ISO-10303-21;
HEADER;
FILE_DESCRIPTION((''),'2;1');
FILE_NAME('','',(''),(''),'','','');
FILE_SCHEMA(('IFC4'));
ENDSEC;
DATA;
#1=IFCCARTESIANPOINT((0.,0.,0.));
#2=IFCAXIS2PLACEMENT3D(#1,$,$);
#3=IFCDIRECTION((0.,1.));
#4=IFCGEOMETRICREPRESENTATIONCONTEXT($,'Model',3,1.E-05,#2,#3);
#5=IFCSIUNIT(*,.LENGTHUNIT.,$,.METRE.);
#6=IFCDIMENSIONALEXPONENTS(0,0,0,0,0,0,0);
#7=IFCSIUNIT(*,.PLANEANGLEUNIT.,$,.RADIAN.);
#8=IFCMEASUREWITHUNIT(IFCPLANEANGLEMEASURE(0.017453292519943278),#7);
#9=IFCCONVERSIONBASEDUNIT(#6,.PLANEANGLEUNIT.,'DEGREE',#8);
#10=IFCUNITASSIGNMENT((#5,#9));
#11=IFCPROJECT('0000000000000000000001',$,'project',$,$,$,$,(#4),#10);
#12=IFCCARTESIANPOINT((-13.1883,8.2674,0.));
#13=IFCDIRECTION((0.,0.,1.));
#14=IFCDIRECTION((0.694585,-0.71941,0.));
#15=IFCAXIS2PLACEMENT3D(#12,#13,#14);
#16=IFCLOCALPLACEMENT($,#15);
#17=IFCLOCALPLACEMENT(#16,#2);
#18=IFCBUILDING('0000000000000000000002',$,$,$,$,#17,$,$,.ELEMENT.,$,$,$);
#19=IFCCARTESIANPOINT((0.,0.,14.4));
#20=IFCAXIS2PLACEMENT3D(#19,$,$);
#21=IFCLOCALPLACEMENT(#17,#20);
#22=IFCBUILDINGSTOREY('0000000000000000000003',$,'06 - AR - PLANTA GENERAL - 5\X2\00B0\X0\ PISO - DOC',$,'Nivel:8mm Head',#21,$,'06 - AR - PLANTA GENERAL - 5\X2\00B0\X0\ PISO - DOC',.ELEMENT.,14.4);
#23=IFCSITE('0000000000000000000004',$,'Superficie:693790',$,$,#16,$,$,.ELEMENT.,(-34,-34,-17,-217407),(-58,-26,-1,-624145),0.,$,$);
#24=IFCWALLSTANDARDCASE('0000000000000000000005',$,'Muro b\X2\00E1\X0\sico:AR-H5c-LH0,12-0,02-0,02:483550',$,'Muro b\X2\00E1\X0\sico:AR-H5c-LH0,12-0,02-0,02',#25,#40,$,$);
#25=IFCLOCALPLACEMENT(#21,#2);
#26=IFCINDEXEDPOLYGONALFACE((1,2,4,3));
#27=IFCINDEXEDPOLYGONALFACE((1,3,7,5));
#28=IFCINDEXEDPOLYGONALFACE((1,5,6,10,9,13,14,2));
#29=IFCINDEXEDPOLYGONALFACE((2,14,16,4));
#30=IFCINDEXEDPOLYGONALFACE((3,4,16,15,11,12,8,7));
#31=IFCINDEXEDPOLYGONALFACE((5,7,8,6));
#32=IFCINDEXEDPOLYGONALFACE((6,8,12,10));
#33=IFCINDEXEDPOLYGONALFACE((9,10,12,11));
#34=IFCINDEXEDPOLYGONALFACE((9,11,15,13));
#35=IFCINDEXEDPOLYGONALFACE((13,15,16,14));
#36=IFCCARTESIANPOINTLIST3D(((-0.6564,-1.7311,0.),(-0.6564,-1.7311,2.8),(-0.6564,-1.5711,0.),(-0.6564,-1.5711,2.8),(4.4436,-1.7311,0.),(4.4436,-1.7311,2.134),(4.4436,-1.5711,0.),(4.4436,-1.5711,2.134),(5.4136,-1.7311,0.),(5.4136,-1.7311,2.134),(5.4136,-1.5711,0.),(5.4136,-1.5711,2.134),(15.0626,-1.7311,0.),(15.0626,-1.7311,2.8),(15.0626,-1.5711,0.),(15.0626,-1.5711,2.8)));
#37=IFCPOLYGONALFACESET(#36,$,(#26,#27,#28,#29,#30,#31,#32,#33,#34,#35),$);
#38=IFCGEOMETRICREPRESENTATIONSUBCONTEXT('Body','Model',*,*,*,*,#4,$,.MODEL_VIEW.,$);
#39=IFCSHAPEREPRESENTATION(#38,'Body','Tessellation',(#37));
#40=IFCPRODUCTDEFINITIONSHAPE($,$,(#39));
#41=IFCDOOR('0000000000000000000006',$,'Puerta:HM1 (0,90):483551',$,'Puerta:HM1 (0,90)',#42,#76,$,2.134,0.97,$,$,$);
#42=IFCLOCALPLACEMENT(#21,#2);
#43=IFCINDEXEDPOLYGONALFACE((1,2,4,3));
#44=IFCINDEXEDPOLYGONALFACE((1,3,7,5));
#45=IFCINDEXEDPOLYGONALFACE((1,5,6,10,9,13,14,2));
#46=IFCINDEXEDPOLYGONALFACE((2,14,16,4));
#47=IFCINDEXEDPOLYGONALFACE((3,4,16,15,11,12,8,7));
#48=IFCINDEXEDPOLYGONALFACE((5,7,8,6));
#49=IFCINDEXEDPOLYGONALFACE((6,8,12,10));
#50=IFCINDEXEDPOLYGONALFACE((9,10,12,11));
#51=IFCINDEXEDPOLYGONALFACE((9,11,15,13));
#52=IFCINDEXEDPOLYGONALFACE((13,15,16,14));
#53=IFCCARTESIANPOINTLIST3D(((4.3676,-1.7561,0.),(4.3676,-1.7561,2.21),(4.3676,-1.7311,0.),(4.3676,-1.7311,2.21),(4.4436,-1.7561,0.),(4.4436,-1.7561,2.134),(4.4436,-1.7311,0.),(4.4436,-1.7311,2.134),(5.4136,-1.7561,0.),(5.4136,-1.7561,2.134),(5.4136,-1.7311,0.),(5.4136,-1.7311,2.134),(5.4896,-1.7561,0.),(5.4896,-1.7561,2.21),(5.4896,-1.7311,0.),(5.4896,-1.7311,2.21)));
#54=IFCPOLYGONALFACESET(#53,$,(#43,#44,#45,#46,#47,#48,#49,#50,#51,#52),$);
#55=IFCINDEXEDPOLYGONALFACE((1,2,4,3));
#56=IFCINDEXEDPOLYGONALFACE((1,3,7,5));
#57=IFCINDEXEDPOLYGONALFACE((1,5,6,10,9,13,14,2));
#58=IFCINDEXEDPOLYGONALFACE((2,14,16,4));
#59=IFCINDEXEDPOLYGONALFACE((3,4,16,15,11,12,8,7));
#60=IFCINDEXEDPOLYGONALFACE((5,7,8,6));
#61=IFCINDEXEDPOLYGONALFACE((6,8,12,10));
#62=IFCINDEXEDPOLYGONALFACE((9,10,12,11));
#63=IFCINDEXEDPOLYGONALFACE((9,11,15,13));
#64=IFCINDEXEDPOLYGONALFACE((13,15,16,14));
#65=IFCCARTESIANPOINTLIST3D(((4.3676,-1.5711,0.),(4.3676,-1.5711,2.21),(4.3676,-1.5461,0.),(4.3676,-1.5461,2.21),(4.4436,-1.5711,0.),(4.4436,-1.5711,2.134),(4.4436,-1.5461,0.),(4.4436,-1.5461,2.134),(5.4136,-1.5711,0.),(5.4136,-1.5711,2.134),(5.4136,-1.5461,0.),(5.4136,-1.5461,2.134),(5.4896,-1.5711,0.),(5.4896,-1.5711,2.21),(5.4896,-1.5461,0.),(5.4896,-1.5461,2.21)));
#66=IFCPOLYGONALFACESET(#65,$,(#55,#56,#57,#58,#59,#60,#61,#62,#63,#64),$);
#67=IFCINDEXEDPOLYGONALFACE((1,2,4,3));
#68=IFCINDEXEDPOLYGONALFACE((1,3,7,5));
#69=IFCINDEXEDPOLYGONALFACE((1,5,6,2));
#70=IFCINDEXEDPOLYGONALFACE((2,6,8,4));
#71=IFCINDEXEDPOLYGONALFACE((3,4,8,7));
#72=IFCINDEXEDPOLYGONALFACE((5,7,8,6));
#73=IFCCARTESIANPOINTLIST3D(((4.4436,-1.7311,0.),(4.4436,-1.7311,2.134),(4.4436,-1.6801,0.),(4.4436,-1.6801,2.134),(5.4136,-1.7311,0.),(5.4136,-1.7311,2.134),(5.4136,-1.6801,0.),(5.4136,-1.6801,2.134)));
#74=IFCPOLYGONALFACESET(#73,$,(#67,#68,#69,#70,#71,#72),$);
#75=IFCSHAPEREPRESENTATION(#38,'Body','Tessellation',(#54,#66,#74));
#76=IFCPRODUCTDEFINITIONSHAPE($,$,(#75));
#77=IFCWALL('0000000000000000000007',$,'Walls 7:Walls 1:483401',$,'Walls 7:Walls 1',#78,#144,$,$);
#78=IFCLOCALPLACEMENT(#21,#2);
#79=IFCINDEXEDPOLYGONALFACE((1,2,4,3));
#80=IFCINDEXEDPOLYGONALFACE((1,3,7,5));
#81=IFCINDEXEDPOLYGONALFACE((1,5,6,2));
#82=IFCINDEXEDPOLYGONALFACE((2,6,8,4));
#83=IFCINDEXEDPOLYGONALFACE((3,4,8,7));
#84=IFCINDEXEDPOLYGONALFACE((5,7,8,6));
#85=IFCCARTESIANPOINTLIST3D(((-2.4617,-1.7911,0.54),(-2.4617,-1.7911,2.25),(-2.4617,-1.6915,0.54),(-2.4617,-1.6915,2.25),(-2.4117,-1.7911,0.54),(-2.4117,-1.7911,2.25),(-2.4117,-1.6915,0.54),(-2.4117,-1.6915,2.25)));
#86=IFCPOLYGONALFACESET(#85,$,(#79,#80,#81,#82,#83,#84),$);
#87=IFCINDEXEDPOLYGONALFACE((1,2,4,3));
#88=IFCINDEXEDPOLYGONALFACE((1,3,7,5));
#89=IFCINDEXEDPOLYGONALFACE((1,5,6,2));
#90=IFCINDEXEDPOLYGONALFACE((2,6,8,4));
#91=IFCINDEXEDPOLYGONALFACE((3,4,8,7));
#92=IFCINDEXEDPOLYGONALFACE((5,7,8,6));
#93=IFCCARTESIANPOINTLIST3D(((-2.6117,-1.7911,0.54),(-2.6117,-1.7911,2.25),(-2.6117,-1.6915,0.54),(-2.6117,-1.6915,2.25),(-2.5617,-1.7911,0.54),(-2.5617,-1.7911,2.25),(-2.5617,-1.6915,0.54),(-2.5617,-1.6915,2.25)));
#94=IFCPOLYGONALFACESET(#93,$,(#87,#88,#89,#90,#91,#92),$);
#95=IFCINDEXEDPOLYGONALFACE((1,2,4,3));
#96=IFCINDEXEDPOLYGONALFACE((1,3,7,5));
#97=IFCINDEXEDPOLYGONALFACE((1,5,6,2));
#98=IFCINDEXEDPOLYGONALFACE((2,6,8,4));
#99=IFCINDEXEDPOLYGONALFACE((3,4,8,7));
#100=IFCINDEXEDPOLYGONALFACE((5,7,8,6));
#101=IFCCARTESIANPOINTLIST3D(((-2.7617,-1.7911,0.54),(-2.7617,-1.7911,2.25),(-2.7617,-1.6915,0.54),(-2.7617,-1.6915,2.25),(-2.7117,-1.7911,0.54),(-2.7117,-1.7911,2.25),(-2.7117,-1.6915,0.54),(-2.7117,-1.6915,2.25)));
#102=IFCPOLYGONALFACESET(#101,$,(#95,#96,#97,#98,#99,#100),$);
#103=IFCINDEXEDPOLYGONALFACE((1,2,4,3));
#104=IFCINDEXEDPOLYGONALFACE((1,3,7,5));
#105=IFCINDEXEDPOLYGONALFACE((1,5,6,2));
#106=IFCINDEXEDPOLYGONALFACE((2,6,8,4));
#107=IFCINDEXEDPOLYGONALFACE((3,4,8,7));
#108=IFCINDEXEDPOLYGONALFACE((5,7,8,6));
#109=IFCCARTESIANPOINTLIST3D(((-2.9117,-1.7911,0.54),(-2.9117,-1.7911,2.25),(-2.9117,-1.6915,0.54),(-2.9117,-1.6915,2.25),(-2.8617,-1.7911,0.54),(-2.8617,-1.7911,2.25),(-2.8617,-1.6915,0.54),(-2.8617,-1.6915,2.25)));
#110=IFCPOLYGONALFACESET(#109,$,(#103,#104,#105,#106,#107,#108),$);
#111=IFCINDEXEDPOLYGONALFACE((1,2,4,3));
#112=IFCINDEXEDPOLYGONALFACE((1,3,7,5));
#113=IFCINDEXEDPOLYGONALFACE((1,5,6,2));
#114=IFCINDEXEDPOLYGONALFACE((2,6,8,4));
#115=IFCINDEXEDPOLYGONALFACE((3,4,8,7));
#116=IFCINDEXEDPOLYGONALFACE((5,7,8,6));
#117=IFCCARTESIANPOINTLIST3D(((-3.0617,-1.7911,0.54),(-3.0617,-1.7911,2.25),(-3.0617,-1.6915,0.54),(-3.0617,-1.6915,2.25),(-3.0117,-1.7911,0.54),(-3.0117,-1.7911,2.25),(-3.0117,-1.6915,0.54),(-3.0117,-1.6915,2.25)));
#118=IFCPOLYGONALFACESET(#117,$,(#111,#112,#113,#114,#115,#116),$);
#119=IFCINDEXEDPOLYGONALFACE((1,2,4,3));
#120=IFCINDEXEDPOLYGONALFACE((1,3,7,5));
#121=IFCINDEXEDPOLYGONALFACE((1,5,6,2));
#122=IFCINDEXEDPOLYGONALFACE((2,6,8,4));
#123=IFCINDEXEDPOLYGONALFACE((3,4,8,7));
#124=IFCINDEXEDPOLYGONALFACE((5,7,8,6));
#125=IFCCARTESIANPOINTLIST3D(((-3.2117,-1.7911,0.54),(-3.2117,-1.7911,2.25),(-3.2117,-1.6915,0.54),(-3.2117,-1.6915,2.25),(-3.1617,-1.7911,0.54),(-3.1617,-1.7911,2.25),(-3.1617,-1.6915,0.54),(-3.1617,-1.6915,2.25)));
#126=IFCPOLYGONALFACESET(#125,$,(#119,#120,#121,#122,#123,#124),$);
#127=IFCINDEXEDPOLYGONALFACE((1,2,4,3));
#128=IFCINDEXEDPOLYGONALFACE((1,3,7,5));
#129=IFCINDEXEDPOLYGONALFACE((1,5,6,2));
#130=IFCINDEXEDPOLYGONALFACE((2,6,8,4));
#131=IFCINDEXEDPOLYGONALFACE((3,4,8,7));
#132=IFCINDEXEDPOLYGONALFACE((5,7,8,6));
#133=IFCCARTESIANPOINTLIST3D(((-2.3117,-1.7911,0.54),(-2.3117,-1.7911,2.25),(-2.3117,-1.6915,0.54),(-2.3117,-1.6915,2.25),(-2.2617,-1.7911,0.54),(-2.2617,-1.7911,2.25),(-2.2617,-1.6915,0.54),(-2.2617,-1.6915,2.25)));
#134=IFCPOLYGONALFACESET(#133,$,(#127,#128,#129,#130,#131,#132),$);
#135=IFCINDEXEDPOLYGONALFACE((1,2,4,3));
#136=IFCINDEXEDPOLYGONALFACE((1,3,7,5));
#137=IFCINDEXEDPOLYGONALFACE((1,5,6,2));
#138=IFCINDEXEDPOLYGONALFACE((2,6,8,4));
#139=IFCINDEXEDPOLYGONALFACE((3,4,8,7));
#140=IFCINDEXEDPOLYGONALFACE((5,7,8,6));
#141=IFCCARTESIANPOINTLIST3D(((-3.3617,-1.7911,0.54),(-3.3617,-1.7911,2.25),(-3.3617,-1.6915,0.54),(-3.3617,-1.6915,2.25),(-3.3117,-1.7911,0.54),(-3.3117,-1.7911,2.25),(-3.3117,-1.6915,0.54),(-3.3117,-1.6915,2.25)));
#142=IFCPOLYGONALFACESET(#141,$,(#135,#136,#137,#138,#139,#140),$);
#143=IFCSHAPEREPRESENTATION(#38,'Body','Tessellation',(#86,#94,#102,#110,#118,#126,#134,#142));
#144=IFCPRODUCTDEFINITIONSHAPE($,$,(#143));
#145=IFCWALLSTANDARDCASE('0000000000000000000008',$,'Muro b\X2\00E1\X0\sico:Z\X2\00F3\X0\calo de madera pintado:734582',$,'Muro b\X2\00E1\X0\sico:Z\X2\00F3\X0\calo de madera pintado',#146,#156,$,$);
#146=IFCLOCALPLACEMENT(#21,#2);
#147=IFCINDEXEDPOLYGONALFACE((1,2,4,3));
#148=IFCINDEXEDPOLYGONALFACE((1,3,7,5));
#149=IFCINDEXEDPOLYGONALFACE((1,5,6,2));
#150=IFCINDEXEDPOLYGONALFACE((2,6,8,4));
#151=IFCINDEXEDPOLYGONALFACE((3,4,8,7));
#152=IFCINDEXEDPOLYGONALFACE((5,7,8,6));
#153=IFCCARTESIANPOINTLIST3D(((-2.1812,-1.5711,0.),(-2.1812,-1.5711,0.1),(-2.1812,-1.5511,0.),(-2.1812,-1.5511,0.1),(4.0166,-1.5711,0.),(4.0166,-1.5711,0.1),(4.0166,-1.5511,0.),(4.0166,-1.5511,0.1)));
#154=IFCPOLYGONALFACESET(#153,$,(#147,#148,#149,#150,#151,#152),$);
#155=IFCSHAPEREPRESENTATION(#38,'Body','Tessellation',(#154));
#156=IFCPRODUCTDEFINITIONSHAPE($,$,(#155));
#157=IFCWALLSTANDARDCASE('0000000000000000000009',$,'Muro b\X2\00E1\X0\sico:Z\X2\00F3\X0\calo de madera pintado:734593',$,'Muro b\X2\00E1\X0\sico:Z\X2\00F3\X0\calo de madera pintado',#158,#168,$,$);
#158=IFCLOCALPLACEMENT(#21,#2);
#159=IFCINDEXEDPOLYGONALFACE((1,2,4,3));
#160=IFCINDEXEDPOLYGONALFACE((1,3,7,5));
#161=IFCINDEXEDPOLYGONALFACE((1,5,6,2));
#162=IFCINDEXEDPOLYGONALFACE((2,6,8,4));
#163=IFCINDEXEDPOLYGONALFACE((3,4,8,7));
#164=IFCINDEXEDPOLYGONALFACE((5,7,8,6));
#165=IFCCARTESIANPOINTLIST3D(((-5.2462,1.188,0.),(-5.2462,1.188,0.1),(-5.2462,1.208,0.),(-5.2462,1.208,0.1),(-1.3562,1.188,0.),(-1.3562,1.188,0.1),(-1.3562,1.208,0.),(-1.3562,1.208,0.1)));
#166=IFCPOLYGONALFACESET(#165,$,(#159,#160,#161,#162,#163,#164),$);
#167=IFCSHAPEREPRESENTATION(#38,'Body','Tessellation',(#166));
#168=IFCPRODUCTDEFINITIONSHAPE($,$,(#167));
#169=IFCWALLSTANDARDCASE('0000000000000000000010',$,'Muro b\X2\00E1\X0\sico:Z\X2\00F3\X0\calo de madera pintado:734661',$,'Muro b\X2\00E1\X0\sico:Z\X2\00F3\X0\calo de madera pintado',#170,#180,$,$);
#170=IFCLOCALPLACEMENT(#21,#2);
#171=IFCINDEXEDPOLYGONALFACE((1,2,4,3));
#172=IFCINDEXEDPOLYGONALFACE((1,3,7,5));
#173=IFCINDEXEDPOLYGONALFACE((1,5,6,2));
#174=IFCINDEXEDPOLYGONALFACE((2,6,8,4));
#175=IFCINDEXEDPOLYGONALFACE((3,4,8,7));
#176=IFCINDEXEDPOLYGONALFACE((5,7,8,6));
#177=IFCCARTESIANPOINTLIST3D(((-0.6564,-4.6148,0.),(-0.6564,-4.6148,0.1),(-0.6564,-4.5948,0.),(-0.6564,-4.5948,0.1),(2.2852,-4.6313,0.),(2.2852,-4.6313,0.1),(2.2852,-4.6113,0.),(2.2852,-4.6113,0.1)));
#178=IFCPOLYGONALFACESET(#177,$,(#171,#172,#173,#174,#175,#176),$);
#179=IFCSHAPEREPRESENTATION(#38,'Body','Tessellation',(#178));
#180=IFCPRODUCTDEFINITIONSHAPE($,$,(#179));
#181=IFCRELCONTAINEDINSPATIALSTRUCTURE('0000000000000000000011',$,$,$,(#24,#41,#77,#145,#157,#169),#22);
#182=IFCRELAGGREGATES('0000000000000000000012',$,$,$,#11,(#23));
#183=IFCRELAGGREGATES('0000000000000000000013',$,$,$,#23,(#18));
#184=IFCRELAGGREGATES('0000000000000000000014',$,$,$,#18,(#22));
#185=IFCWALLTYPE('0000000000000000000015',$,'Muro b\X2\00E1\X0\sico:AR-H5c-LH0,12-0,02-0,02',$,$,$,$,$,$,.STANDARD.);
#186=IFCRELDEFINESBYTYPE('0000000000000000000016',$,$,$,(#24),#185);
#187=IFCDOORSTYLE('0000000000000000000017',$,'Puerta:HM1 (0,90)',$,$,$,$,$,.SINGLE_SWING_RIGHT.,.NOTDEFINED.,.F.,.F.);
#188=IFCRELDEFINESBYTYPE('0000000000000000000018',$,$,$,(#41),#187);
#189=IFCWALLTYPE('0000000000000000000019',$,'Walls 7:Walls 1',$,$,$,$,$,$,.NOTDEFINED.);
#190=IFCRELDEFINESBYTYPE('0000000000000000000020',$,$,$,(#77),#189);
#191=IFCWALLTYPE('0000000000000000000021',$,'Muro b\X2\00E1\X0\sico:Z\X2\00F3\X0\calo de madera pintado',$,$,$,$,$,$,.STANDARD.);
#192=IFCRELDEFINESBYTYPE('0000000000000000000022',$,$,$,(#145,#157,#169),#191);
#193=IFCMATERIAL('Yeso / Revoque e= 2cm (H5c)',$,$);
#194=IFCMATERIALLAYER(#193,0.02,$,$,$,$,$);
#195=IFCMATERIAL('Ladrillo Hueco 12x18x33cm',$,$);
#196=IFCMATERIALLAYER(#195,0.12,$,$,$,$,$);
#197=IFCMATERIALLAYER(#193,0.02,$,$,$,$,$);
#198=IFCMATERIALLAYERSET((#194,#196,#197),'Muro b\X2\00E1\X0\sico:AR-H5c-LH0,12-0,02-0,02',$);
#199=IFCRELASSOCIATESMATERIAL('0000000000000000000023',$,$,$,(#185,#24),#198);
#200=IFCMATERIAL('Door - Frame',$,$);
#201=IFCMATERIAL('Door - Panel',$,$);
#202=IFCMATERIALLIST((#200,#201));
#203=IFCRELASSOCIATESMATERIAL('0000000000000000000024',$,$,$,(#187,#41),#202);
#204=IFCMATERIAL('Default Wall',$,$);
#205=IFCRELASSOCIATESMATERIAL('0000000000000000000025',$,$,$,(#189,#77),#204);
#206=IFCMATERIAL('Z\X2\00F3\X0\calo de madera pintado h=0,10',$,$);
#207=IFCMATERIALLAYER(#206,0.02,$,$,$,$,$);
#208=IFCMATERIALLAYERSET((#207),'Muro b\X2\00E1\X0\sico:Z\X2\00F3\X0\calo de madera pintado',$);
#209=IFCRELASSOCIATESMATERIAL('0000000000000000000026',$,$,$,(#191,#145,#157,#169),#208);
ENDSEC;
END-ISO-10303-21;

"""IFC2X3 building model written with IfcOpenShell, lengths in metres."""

from ifc_helpers import new_model, entity, si_unit, converted_unit, direction, frame, frame_2d, origin, place, context, subcontext, project, spatial, polyline, rectangle, outline, extrude, source, transform, mapped, material, material_list, layer, layer_set, layer_usage, type_object, type_shapes, element, fill, save


model = new_model("IFC2X3")

# Units and contexts
model_context = context("Model", 3, precision=1e-05, world=origin(), true_north=direction((0.0, 1.0)))
body_context = subcontext(model_context, "Body", "Model", "MODEL_VIEW")
ifc_project = project(units=[si_unit("LENGTHUNIT", "METRE"), converted_unit("PLANEANGLEUNIT", "DEGREE", entity("IfcPlaneAngleMeasure", 0.017453292519943278), si_unit("PLANEANGLEUNIT", "RADIAN"), dimensions=[0, 0, 0, 0, 0, 0, 0])], contexts=[model_context])

# Site, building, storey
site_placement = place(None, frame((-13.1883, 8.2674, 0.0), z_axis=(0.0, 0.0, 1.0), x_axis=(0.694585, -0.71941, 0.0)))
site = spatial("IfcSite", under=ifc_project, at=site_placement, Name="Superficie:693790", CompositionType="ELEMENT", RefLatitude=(-34, -34, -17, -217407), RefLongitude=(-58, -26, -1, -624145), RefElevation=0.0)
building_placement = place(site_placement, origin())
building = spatial("IfcBuilding", under=site, at=building_placement, CompositionType="ELEMENT")
storey_placement = place(building_placement, frame((0.0, 0.0, 14.4)))
storey = spatial("IfcBuildingStorey", under=building, at=storey_placement, Name="06 - AR - PLANTA GENERAL - 5° PISO - DOC", ObjectType="Nivel:8mm Head", LongName="06 - AR - PLANTA GENERAL - 5° PISO - DOC", CompositionType="ELEMENT", Elevation=14.4)

# Wall, opening, door
ifc_material_1 = material(Name="Yeso / Revoque e= 2cm (H5c)")
ifc_layer_1 = layer(ifc_material_1, 0.02)
ifc_material_2 = material(Name="Ladrillo Hueco 12x18x33cm")
ifc_layer_2 = layer(ifc_material_2, 0.12)
ifc_layer_3 = layer(ifc_material_1, 0.02)
ifc_layer_set_1 = layer_set([ifc_layer_1, ifc_layer_2, ifc_layer_3], Name="Muro básico:AR-H5c-LH0,12-0,02-0,02")
ifc_layer_usage_1 = layer_usage(ifc_layer_set_1, "AXIS2", "NEGATIVE", 0.08)
wall_type_1 = type_object("IfcWallType", Name="Muro básico:AR-H5c-LH0,12-0,02-0,02", PredefinedType="STANDARD", material=ifc_layer_set_1)
wall_1_placement = place(storey_placement, frame((-0.6564, -1.6511, 0.0)))
wall_1 = element("IfcWallStandardCase", 1, at=wall_1_placement, inside=storey, type_object=wall_type_1, material=ifc_layer_usage_1, Name="Muro básico:AR-H5c-LH0,12-0,02-0,02:483550", ObjectType="Muro básico:AR-H5c-LH0,12-0,02-0,02", context=body_context, shape_type="SweptSolid", body=[
    extrude(rectangle(XDim=15.719, YDim=0.16, at=frame_2d((7.8595, 0.0), x_axis=(-1.0, 0.0))), origin(), (0.0, 0.0, 1.0), 2.8),
])
opening_1_placement = place(wall_1_placement, frame((6.07, 0.08, 0.0)))
opening_1 = element("IfcOpeningElement", 2, at=opening_1_placement, cuts=wall_1, ObjectType="Opening", context=body_context, shape_type="SweptSolid", body=[
    extrude(rectangle(XDim=0.97, YDim=2.134, at=frame_2d((1.067, 0.485), x_axis=(0.0, 1.0))), frame((0.0, 0.0, 0.0), z_axis=(0.0, -1.0, 0.0), x_axis=(0.0, 0.0, 1.0)), (0.0, 0.0, 1.0), 0.16),
])
ifc_material_3 = material(Name="Door - Frame")
ifc_material_4 = material(Name="Door - Panel")
ifc_material_list_1 = material_list([ifc_material_3, ifc_material_4])
door_style = type_object("IfcDoorStyle", Name="Puerta:HM1 (0,90)", ConstructionType="NOTDEFINED", OperationType="SINGLE_SWING_RIGHT", ParameterTakesPrecedence=False, Sizeable=False, material=ifc_material_list_1)
shared_shape_1 = source(origin(), body_context, "Body", "SweptSolid", [
    extrude(outline(polyline([(-0.561, -1.124), (0.561, -1.124), (0.561, 1.086), (0.485, 1.086), (0.485, -1.048), (-0.485, -1.048), (-0.485, 1.086), (-0.561, 1.086), (-0.561, -1.124)])), frame((0.485, 0.16, 1.086), z_axis=(0.0, 1.0, 0.0), x_axis=(1.0, 0.0, 0.0)), (0.0, 0.0, 1.0), 0.025),
    extrude(outline(polyline([(-1.124, -0.561), (1.086, -0.561), (1.086, -0.485), (-1.048, -0.485), (-1.048, 0.485), (1.086, 0.485), (1.086, 0.561), (-1.124, 0.561), (-1.124, -0.561)])), frame((0.485, -0.025, 1.086), z_axis=(0.0, 1.0, 0.0), x_axis=(0.0, 0.0, -1.0)), (0.0, 0.0, 1.0), 0.025),
    extrude(rectangle(XDim=0.051, YDim=0.97, at=frame_2d((0.0, 0.0), x_axis=(1.0, 0.0))), frame((0.485, 0.1345, 0.0), z_axis=(0.0, 0.0, 1.0), x_axis=(0.0, 1.0, 0.0)), (0.0, 0.0, 1.0), 2.134),
])
type_shapes(door_style, [shared_shape_1])
door_placement = place(opening_1_placement, frame((0.0, 0.0, 0.0), z_axis=(0.0, 0.0, 1.0), x_axis=(-1.0, 0.0, 0.0)))
door = element("IfcDoor", 3, at=door_placement, inside=storey, type_object=door_style, material=ifc_material_list_1, Name="Puerta:HM1 (0,90):483551", ObjectType="Puerta:HM1 (0,90)", OverallHeight=2.134, OverallWidth=0.97, context=body_context, shape_type="MappedRepresentation", body=[
    mapped(shared_shape_1, transform((0.0, 0.0, 0.0), scale=1.0)),
])
fill(opening_1, door)

# Walls
ifc_material_5 = material(Name="Default Wall")
wall_type_2 = type_object("IfcWallType", Name="Walls 7:Walls 1", PredefinedType="NOTDEFINED", material=ifc_material_5)
wall_2_placement = place(storey_placement, frame((-3.3617, -1.7911, 0.54)))
element("IfcWall", 4, at=wall_2_placement, inside=storey, type_object=wall_type_2, material=ifc_material_5, Name="Walls 7:Walls 1:483401", ObjectType="Walls 7:Walls 1", context=body_context, shape_type="SweptSolid", body=[
    extrude(rectangle(XDim=0.05, YDim=0.0996, at=frame_2d((0.0, 0.0), x_axis=(1.0, 0.0))), frame((0.925, 0.0498, 0.0), z_axis=(0.0, 0.0, 1.0), x_axis=(-1.0, 0.0, 0.0)), (0.0, 0.0, 1.0), 1.71),
    extrude(rectangle(XDim=0.05, YDim=0.0996, at=frame_2d((0.0, 0.0), x_axis=(1.0, 0.0))), frame((0.775, 0.0498, 0.0), z_axis=(0.0, 0.0, 1.0), x_axis=(-1.0, 0.0, 0.0)), (0.0, 0.0, 1.0), 1.71),
    extrude(rectangle(XDim=0.05, YDim=0.0996, at=frame_2d((0.0, 0.0), x_axis=(1.0, 0.0))), frame((0.625, 0.0498, 0.0), z_axis=(0.0, 0.0, 1.0), x_axis=(-1.0, 0.0, 0.0)), (0.0, 0.0, 1.0), 1.71),
    extrude(rectangle(XDim=0.05, YDim=0.0996, at=frame_2d((0.0, 0.0), x_axis=(1.0, 0.0))), frame((0.475, 0.0498, 0.0), z_axis=(0.0, 0.0, 1.0), x_axis=(-1.0, 0.0, 0.0)), (0.0, 0.0, 1.0), 1.71),
    extrude(rectangle(XDim=0.05, YDim=0.0996, at=frame_2d((0.0, 0.0), x_axis=(1.0, 0.0))), frame((0.325, 0.0498, 0.0), z_axis=(0.0, 0.0, 1.0), x_axis=(-1.0, 0.0, 0.0)), (0.0, 0.0, 1.0), 1.71),
    extrude(rectangle(XDim=0.05, YDim=0.0996, at=frame_2d((0.0, 0.0), x_axis=(1.0, 0.0))), frame((0.175, 0.0498, 0.0), z_axis=(0.0, 0.0, 1.0), x_axis=(-1.0, 0.0, 0.0)), (0.0, 0.0, 1.0), 1.71),
    extrude(rectangle(XDim=0.05, YDim=0.0996, at=frame_2d((0.0, 0.0), x_axis=(1.0, 0.0))), frame((1.075, 0.0498, 0.0), z_axis=(0.0, 0.0, 1.0), x_axis=(-1.0, 0.0, 0.0)), (0.0, 0.0, 1.0), 1.71),
    extrude(rectangle(XDim=0.05, YDim=0.0996, at=frame_2d((0.0, 0.0), x_axis=(1.0, 0.0))), frame((0.025, 0.0498, 0.0), z_axis=(0.0, 0.0, 1.0), x_axis=(-1.0, 0.0, 0.0)), (0.0, 0.0, 1.0), 1.71),
])
ifc_material_6 = material(Name="Zócalo de madera pintado h=0,10")
ifc_layer_4 = layer(ifc_material_6, 0.02)
ifc_layer_set_2 = layer_set([ifc_layer_4], Name="Muro básico:Zócalo de madera pintado")
ifc_layer_usage_2 = layer_usage(ifc_layer_set_2, "AXIS2", "NEGATIVE", 0.01)
wall_type_3 = type_object("IfcWallType", Name="Muro básico:Zócalo de madera pintado", PredefinedType="STANDARD", material=ifc_layer_set_2)
wall_3_placement = place(storey_placement, frame((-2.1812, -1.5611, 0.0)))
element("IfcWallStandardCase", 5, at=wall_3_placement, inside=storey, type_object=wall_type_3, material=ifc_layer_usage_2, Name="Muro básico:Zócalo de madera pintado:734582", ObjectType="Muro básico:Zócalo de madera pintado", context=body_context, shape_type="SweptSolid", body=[
    extrude(rectangle(XDim=6.1979, YDim=0.02, at=frame_2d((3.0989, 0.0), x_axis=(-1.0, 0.0))), origin(), (0.0, 0.0, 1.0), 0.1),
])
ifc_layer_usage_3 = layer_usage(ifc_layer_set_2, "AXIS2", "NEGATIVE", 0.01)
wall_4_placement = place(storey_placement, frame((-1.3562, 1.198, 0.0), z_axis=(0.0, 0.0, 1.0), x_axis=(-1.0, 0.0, 0.0)))
element("IfcWallStandardCase", 6, at=wall_4_placement, inside=storey, type_object=wall_type_3, material=ifc_layer_usage_3, Name="Muro básico:Zócalo de madera pintado:734593", ObjectType="Muro básico:Zócalo de madera pintado", context=body_context, shape_type="SweptSolid", body=[
    extrude(rectangle(XDim=3.89, YDim=0.02, at=frame_2d((1.945, 0.0), x_axis=(-1.0, 0.0))), origin(), (0.0, 0.0, 1.0), 0.1),
])
ifc_layer_usage_4 = layer_usage(ifc_layer_set_2, "AXIS2", "NEGATIVE", 0.01)
wall_5_placement = place(storey_placement, frame((-0.6565, -4.6048, 0.0), z_axis=(0.0, 0.0, 1.0), x_axis=(0.999984, -0.005619, 0.0)))
element("IfcWallStandardCase", 7, at=wall_5_placement, inside=storey, type_object=wall_type_3, material=ifc_layer_usage_4, Name="Muro básico:Zócalo de madera pintado:734661", ObjectType="Muro básico:Zócalo de madera pintado", context=body_context, shape_type="SweptSolid", body=[
    extrude(outline(polyline([(2.9417, -0.01), (2.9416, 0.01), (0.0, 0.01), (0.0001, -0.01), (2.9417, -0.01)])), origin(), (0.0, 0.0, 1.0), 0.1),
])

save(model, "model.ifc")
